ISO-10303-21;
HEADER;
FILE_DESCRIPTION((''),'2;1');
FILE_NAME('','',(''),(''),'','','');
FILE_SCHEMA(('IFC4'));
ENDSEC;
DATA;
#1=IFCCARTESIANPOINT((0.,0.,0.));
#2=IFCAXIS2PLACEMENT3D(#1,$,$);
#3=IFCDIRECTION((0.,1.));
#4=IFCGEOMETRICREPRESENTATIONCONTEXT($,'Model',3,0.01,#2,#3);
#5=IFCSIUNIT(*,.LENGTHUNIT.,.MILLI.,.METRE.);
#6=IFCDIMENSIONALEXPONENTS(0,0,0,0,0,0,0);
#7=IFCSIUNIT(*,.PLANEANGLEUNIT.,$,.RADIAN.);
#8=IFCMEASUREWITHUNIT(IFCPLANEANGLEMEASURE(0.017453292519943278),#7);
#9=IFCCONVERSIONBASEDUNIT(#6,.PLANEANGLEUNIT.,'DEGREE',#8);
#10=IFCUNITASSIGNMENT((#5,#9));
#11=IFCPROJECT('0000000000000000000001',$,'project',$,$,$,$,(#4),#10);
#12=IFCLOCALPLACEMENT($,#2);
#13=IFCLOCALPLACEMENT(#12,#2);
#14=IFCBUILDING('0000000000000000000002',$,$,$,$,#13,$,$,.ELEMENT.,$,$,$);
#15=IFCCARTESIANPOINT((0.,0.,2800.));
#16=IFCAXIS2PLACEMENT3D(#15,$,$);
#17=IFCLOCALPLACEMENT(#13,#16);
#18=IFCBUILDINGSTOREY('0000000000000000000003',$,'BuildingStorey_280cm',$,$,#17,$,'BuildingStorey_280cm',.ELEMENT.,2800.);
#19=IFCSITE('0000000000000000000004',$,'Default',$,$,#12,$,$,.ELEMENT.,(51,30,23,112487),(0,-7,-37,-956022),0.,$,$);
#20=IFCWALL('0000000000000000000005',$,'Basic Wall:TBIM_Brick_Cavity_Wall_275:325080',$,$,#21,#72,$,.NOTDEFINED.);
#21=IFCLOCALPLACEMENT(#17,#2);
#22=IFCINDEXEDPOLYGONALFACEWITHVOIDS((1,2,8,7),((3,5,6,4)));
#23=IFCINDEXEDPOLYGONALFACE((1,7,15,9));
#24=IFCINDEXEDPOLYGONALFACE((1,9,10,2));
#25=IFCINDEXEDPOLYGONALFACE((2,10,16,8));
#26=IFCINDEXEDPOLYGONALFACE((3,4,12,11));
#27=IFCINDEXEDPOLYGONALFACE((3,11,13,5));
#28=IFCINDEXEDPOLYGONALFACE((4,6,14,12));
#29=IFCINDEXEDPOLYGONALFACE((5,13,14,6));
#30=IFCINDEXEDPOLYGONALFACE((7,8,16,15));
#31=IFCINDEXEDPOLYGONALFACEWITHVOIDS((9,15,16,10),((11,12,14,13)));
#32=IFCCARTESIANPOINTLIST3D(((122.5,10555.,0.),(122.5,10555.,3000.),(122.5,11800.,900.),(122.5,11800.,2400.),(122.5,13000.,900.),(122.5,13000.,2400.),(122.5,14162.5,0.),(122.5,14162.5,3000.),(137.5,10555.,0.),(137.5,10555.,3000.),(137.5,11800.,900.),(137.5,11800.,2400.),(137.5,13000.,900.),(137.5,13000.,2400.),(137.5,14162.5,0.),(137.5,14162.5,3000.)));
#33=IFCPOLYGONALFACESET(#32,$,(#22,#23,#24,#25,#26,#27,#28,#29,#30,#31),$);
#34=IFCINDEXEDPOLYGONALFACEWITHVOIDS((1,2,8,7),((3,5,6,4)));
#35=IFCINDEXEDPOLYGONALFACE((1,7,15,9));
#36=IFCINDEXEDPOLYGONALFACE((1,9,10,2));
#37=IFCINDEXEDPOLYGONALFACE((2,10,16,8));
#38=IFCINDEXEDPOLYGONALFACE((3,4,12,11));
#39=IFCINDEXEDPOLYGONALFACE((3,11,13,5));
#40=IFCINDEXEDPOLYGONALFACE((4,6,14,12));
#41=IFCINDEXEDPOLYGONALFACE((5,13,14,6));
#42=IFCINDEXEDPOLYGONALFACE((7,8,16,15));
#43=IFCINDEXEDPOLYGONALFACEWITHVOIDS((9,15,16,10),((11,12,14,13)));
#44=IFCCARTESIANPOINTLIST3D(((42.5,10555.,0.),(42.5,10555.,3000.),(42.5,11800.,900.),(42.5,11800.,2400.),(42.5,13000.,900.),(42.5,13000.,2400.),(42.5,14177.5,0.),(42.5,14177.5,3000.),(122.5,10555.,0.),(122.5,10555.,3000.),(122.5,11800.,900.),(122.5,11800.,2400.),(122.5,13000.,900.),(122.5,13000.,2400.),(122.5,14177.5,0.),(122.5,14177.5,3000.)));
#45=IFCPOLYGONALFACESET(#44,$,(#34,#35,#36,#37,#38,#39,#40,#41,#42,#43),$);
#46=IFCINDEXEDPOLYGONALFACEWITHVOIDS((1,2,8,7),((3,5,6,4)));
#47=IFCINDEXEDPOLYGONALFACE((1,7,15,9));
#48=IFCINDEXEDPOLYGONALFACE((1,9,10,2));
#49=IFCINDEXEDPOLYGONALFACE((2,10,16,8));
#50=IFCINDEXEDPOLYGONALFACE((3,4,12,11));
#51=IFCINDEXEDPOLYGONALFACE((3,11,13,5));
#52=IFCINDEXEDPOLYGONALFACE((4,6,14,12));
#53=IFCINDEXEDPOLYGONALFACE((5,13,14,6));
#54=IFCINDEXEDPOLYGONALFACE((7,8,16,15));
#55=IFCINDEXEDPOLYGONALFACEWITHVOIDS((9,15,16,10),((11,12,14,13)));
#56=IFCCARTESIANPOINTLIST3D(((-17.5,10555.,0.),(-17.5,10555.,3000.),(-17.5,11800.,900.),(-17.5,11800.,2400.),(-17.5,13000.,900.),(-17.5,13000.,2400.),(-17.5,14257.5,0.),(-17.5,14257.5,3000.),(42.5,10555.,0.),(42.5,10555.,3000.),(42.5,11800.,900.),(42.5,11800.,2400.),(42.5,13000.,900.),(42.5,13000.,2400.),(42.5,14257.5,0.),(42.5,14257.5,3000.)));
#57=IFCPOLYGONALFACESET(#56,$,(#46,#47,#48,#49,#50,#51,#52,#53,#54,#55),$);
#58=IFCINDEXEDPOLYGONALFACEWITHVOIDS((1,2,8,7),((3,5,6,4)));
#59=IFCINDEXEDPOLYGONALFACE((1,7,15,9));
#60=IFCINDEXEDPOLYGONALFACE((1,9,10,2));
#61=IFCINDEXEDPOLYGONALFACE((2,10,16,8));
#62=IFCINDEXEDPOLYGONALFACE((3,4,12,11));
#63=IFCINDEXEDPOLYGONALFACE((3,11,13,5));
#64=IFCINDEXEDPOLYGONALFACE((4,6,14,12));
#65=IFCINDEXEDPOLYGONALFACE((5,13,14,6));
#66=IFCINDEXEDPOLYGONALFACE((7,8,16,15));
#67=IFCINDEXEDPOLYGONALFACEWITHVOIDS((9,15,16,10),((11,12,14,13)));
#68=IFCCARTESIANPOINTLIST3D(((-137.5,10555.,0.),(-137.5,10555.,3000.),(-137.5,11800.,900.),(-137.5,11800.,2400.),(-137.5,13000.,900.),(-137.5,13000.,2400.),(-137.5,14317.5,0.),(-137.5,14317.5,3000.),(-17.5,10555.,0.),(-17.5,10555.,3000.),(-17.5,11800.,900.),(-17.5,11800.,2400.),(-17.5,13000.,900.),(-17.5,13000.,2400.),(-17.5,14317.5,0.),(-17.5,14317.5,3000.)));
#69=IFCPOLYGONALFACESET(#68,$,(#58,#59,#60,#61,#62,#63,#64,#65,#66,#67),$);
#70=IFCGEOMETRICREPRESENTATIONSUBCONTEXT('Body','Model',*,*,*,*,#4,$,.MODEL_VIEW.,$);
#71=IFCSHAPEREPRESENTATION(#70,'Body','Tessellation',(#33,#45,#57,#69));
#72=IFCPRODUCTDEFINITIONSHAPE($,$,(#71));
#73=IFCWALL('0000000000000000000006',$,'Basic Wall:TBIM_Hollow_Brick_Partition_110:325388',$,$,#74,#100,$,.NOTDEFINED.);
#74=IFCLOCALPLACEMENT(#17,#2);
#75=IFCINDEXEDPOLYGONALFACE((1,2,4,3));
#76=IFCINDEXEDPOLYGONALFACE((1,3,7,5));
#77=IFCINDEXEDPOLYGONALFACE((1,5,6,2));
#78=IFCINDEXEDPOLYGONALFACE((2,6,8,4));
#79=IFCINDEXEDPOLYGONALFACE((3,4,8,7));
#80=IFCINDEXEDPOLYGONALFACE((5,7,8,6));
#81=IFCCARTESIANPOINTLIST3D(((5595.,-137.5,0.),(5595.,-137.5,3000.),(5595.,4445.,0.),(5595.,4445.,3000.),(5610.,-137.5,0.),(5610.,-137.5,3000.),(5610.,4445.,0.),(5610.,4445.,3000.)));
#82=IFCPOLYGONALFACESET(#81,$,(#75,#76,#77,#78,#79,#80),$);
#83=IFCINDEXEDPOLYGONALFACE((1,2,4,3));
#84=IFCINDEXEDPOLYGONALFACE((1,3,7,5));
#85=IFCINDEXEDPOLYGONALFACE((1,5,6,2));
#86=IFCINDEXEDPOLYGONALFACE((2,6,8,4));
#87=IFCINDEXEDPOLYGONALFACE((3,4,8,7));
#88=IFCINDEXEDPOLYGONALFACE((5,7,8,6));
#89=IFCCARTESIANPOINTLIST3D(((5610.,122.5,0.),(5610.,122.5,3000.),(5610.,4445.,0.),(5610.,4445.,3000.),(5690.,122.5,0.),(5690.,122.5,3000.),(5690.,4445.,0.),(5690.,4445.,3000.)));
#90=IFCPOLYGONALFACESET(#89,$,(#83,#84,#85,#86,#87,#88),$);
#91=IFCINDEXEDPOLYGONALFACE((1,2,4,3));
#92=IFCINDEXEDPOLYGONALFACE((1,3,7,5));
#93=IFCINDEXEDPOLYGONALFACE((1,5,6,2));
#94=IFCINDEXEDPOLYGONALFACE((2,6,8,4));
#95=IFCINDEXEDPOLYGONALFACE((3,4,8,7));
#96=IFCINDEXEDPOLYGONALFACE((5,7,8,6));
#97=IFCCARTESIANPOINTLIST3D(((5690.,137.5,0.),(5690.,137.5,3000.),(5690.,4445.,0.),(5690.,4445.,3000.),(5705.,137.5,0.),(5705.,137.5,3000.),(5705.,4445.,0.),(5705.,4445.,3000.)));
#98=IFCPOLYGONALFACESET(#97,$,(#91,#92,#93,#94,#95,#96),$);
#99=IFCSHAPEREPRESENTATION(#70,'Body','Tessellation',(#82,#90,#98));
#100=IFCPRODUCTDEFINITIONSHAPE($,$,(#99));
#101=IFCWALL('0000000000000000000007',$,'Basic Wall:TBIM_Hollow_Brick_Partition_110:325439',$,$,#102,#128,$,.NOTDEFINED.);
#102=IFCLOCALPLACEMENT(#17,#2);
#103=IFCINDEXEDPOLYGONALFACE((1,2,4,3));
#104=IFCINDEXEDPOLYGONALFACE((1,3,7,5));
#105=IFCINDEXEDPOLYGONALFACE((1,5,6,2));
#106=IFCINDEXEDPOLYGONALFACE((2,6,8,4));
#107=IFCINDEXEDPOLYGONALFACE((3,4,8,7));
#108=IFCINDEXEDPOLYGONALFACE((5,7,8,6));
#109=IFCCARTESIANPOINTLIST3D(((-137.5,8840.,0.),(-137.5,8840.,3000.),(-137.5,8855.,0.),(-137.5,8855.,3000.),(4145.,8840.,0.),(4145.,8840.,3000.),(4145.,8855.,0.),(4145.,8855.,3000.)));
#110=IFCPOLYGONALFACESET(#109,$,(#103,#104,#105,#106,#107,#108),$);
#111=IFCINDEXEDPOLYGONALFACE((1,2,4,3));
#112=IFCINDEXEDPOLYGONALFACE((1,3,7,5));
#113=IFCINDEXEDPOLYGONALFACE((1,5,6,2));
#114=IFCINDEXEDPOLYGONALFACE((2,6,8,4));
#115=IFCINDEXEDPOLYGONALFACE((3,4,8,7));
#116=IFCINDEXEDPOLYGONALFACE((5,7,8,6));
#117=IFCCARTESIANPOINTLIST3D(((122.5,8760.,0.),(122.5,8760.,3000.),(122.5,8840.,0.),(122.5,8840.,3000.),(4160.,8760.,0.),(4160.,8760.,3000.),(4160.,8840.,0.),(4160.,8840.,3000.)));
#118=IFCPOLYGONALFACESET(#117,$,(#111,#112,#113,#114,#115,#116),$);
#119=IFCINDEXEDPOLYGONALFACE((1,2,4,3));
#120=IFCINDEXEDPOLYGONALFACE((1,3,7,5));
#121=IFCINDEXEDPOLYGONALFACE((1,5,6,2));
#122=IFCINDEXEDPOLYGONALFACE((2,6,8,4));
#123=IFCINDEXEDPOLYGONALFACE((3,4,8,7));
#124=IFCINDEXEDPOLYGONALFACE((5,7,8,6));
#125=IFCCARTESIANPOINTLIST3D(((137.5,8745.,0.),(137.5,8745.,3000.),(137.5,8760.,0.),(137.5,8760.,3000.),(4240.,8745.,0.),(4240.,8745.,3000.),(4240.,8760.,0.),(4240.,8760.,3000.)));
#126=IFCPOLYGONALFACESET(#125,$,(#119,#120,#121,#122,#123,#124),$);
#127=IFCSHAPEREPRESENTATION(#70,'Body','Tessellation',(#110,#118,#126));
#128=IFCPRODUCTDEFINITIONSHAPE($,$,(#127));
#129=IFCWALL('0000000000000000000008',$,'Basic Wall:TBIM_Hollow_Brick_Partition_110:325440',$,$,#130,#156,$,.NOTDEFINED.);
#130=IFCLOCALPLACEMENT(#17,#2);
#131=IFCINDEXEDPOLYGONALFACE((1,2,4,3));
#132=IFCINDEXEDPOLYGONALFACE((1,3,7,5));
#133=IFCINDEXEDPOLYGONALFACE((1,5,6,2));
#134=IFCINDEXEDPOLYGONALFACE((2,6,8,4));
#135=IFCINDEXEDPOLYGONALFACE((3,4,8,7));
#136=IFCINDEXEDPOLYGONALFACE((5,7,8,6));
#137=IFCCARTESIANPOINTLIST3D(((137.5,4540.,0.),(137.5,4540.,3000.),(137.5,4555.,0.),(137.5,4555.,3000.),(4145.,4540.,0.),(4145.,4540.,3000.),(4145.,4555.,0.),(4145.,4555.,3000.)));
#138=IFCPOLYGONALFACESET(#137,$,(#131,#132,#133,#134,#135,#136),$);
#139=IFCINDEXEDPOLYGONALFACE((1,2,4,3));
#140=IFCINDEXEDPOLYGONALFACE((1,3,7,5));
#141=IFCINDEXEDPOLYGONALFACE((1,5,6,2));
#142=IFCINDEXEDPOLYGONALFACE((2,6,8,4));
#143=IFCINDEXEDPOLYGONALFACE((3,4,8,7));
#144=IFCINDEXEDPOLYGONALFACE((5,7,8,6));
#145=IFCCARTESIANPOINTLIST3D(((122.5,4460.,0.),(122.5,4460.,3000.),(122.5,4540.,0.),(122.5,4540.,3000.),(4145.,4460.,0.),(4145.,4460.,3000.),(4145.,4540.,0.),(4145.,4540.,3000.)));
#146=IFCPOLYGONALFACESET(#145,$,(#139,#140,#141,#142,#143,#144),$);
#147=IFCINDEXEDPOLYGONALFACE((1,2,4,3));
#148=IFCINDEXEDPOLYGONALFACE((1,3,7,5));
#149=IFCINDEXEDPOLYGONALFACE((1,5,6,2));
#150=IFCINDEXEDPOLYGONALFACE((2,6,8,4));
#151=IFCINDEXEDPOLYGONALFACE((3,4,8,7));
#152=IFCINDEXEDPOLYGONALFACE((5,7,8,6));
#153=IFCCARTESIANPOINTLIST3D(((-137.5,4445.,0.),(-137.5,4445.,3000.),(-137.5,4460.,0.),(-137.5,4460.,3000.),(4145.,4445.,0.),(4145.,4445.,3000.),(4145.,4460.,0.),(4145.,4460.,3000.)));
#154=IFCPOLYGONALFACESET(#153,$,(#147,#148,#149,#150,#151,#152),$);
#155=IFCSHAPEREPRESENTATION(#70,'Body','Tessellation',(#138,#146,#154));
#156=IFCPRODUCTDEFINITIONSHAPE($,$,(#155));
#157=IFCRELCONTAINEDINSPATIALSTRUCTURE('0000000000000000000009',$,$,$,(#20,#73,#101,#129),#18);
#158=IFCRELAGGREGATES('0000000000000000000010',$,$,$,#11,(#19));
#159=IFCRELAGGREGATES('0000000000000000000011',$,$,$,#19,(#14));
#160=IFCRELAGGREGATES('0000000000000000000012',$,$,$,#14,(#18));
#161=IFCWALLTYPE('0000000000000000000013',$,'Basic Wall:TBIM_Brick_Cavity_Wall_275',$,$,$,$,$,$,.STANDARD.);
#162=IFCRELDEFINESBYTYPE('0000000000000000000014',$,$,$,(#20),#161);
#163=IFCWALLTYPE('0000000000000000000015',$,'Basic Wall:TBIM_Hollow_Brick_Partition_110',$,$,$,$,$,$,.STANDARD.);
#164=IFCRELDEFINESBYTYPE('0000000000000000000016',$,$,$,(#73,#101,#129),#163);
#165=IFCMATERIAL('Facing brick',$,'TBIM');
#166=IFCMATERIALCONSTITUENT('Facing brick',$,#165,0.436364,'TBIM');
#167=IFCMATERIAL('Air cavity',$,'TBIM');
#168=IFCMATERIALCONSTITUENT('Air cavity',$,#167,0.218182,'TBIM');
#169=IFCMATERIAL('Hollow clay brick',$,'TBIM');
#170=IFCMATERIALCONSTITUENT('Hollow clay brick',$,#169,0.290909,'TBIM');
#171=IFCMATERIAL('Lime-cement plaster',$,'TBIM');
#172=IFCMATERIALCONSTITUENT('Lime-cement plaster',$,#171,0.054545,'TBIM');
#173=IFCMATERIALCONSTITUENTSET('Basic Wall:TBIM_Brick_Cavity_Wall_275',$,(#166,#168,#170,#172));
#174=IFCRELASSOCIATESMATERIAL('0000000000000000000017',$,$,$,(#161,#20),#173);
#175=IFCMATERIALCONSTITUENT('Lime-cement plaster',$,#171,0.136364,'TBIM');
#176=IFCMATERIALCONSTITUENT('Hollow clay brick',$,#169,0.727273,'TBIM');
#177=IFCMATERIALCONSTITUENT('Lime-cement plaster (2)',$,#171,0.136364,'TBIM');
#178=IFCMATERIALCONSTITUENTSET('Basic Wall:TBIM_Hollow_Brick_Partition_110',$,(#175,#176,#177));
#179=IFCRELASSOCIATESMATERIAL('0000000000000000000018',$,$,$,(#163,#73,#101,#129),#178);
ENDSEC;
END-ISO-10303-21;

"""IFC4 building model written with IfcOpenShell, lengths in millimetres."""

from ifc_helpers import new_model, entity, si_unit, converted_unit, direction, frame, origin, place, context, subcontext, project, spatial, indexed_curve, outline, extrude, material, constituent, constituent_set, type_object, element, save


model = new_model("IFC4")

# Units and contexts
model_context = context("Model", 3, precision=0.01, world=origin(), true_north=direction((0.0, 1.0)))
body_context = subcontext(model_context, "Body", "Model", "MODEL_VIEW")
ifc_project = project(units=[si_unit("LENGTHUNIT", "METRE", prefix="MILLI"), converted_unit("PLANEANGLEUNIT", "DEGREE", entity("IfcPlaneAngleMeasure", 0.017453292519943278), si_unit("PLANEANGLEUNIT", "RADIAN"), dimensions=[0, 0, 0, 0, 0, 0, 0])], contexts=[model_context])

# Site, building, storey
site_placement = place(None, origin())
site = spatial("IfcSite", under=ifc_project, at=site_placement, Name="Default", CompositionType="ELEMENT", RefLatitude=(51, 30, 23, 112487), RefLongitude=(0, -7, -37, -956022), RefElevation=0.0)
building_placement = place(site_placement, origin())
building = spatial("IfcBuilding", under=site, at=building_placement, CompositionType="ELEMENT")
storey_placement = place(building_placement, frame((0.0, 0.0, 2800.0)))
storey = spatial("IfcBuildingStorey", under=building, at=storey_placement, Name="BuildingStorey_280cm", LongName="BuildingStorey_280cm", CompositionType="ELEMENT", Elevation=2800.0)

# Shared definitions
ifc_material_1 = material(Name="Lime-cement plaster", Category="TBIM")

# Shared definitions
ifc_material_2 = material(Name="Facing brick", Category="TBIM")
ifc_constituent_1 = constituent(ifc_material_2, Name="Facing brick", Category="TBIM", fraction=0.436364)
ifc_material_3 = material(Name="Air cavity", Category="TBIM")
ifc_constituent_2 = constituent(ifc_material_3, Name="Air cavity", Category="TBIM", fraction=0.218182)
ifc_material_4 = material(Name="Hollow clay brick", Category="TBIM")
ifc_constituent_3 = constituent(ifc_material_4, Name="Hollow clay brick", Category="TBIM", fraction=0.290909)
ifc_constituent_4 = constituent(ifc_material_1, Name="Lime-cement plaster", Category="TBIM", fraction=0.054545)
ifc_constituent_set_1 = constituent_set(constituents=[ifc_constituent_1, ifc_constituent_2, ifc_constituent_3, ifc_constituent_4], Name="Basic Wall:TBIM_Brick_Cavity_Wall_275")
wall_type_1 = type_object("IfcWallType", Name="Basic Wall:TBIM_Brick_Cavity_Wall_275", PredefinedType="STANDARD", material=ifc_constituent_set_1)

# Wall, opening
wall_1_placement = place(storey_placement, frame((0.0, 10555.0, 0.0), z_axis=(0.0, 0.0, 1.0), x_axis=(0.0, 1.0, 0.0)))
wall_1 = element("IfcWall", 1, at=wall_1_placement, inside=storey, type_object=wall_type_1, material=ifc_constituent_set_1, Name="Basic Wall:TBIM_Brick_Cavity_Wall_275:325080", PredefinedType="NOTDEFINED", context=body_context, shape_type="SweptSolid", body=[
    extrude(outline(indexed_curve([(-1500.0, -1803.7), (1500.0, -1803.8), (1500.0, 1803.7), (-1500.0, 1803.7), (-1500.0, -1803.7)], self_intersect=False), holes=[indexed_curve([(900.0, 558.8), (900.0, -641.2), (-600.0, -641.2), (-600.0, 558.8), (900.0, 558.8)], self_intersect=False)]), frame((1803.7, -122.5, 1500.0), z_axis=(0.0, -1.0, 0.0), x_axis=(0.0, 0.0, 1.0)), (0.0, 0.0, 1.0), 15.0),
    extrude(outline(indexed_curve([(-1500.0, -1811.2), (1500.0, -1811.2), (1500.0, 1811.2), (-1500.0, 1811.2), (-1500.0, -1811.2)], self_intersect=False), holes=[indexed_curve([(900.0, 566.3), (900.0, -633.7), (-600.0, -633.7), (-600.0, 566.3), (900.0, 566.3)], self_intersect=False)]), frame((1811.2, -42.5, 1500.0), z_axis=(0.0, -1.0, 0.0), x_axis=(0.0, 0.0, 1.0)), (0.0, 0.0, 1.0), 80.0),
    extrude(outline(indexed_curve([(-1500.0, -1851.2), (1500.0, -1851.2), (1500.0, 1851.2), (-1500.0, 1851.2), (-1500.0, -1851.2)], self_intersect=False), holes=[indexed_curve([(900.0, 606.3), (900.0, -593.7), (-600.0, -593.7), (-600.0, 606.3), (900.0, 606.3)], self_intersect=False)]), frame((1851.2, 17.5, 1500.0), z_axis=(0.0, -1.0, 0.0), x_axis=(0.0, 0.0, 1.0)), (0.0, 0.0, 1.0), 60.0),
    extrude(outline(indexed_curve([(-1881.2, -1500.0), (1881.2, -1500.0), (1881.2, 1500.0), (-1881.2, 1500.0), (-1881.2, -1500.0)], self_intersect=False), holes=[indexed_curve([(-636.3, 900.0), (563.7, 900.0), (563.7, -600.0), (-636.3, -600.0), (-636.3, 900.0)], self_intersect=False)]), frame((1881.2, 137.5, 1500.0), z_axis=(0.0, -1.0, 0.0), x_axis=(1.0, 0.0, 0.0)), (0.0, 0.0, 1.0), 120.0),
])
opening_1_placement = place(wall_1_placement, frame((1245.0, -137.5, 900.0)))
element("IfcOpeningElement", 2, at=opening_1_placement, cuts=wall_1, PredefinedType="OPENING", context=body_context, shape_type="SweptSolid", body=[
    extrude(outline(indexed_curve([(1500.0, 0.0), (1500.0, 1200.0), (0.0, 1200.0), (0.0, 0.0), (1500.0, 0.0)], self_intersect=False)), frame((0.0, 0.0, 0.0), z_axis=(0.0, 1.0, 0.0), x_axis=(0.0, 0.0, 1.0)), (0.0, 0.0, 1.0), 275.0),
])

# Wall
ifc_constituent_5 = constituent(ifc_material_1, Name="Lime-cement plaster", Category="TBIM", fraction=0.136364)
ifc_constituent_6 = constituent(ifc_material_4, Name="Hollow clay brick", Category="TBIM", fraction=0.727273)
ifc_constituent_7 = constituent(ifc_material_1, Name="Lime-cement plaster (2)", Category="TBIM", fraction=0.136364)
ifc_constituent_set_2 = constituent_set(constituents=[ifc_constituent_5, ifc_constituent_6, ifc_constituent_7], Name="Basic Wall:TBIM_Hollow_Brick_Partition_110")
wall_type_2 = type_object("IfcWallType", Name="Basic Wall:TBIM_Hollow_Brick_Partition_110", PredefinedType="STANDARD", material=ifc_constituent_set_2)
wall_2_placement = place(storey_placement, frame((5650.0, 137.5, 0.0), z_axis=(0.0, 0.0, 1.0), x_axis=(0.0, 1.0, 0.0)))
element("IfcWall", 3, at=wall_2_placement, inside=storey, type_object=wall_type_2, material=ifc_constituent_set_2, Name="Basic Wall:TBIM_Hollow_Brick_Partition_110:325388", PredefinedType="NOTDEFINED", context=body_context, shape_type="SweptSolid", body=[
    extrude(outline(indexed_curve([(-7.5, -2291.2), (7.5, -2291.2), (7.5, 2291.2), (-7.5, 2291.2), (-7.5, -2291.2)], self_intersect=False)), frame((2016.2, 47.5, 0.0), z_axis=(0.0, 0.0, 1.0), x_axis=(0.0, -1.0, 0.0)), (0.0, 0.0, 1.0), 3000.0),
    extrude(outline(indexed_curve([(-2161.2, -40.0), (2161.2, -40.0), (2161.2, 40.0), (-2161.3, 40.0), (-2161.2, -40.0)], self_intersect=False)), frame((2146.2, 0.0, 0.0)), (0.0, 0.0, 1.0), 3000.0),
    extrude(outline(indexed_curve([(-7.5, -2153.8), (7.5, -2153.8), (7.5, 2153.8), (-7.5, 2153.8), (-7.5, -2153.8)], self_intersect=False)), frame((2153.8, -47.5, 0.0), z_axis=(0.0, 0.0, 1.0), x_axis=(0.0, 1.0, 0.0)), (0.0, 0.0, 1.0), 3000.0),
])

# Walls
wall_3_placement = place(storey_placement, frame((137.5, 8800.0, 0.0)))
element("IfcWall", 4, at=wall_3_placement, inside=storey, type_object=wall_type_2, material=ifc_constituent_set_2, Name="Basic Wall:TBIM_Hollow_Brick_Partition_110:325439", PredefinedType="NOTDEFINED", context=body_context, shape_type="SweptSolid", body=[
    extrude(outline(indexed_curve([(-7.5, -2141.2), (7.5, -2141.2), (7.5, 2141.2), (-7.5, 2141.2), (-7.5, -2141.2)], self_intersect=False)), frame((1866.2, 47.5, 0.0), z_axis=(0.0, 0.0, 1.0), x_axis=(0.0, -1.0, 0.0)), (0.0, 0.0, 1.0), 3000.0),
    extrude(outline(indexed_curve([(-2018.7, -40.0), (2018.7, -40.0), (2018.7, 40.0), (-2018.7, 40.0), (-2018.7, -40.0)], self_intersect=False)), frame((2003.7, 0.0, 0.0)), (0.0, 0.0, 1.0), 3000.0),
    extrude(outline(indexed_curve([(-7.5, -2051.2), (7.5, -2051.2), (7.5, 2051.2), (-7.5, 2051.2), (-7.5, -2051.2)], self_intersect=False)), frame((2051.2, -47.5, 0.0), z_axis=(0.0, 0.0, 1.0), x_axis=(0.0, 1.0, 0.0)), (0.0, 0.0, 1.0), 3000.0),
])
wall_4_placement = place(storey_placement, frame((137.5, 4500.0, 0.0)))
element("IfcWall", 5, at=wall_4_placement, inside=storey, type_object=wall_type_2, material=ifc_constituent_set_2, Name="Basic Wall:TBIM_Hollow_Brick_Partition_110:325440", PredefinedType="NOTDEFINED", context=body_context, shape_type="SweptSolid", body=[
    extrude(outline(indexed_curve([(-7.5, -2003.7), (7.5, -2003.7), (7.5, 2003.7), (-7.5, 2003.7), (-7.5, -2003.7)], self_intersect=False)), frame((2003.7, 47.5, 0.0), z_axis=(0.0, 0.0, 1.0), x_axis=(0.0, -1.0, 0.0)), (0.0, 0.0, 1.0), 3000.0),
    extrude(outline(indexed_curve([(-2011.2, -40.0), (2011.2, -40.0), (2011.2, 40.0), (-2011.2, 40.0), (-2011.2, -40.0)], self_intersect=False)), frame((1996.2, 0.0, 0.0)), (0.0, 0.0, 1.0), 3000.0),
    extrude(outline(indexed_curve([(-7.5, -2141.2), (7.5, -2141.2), (7.5, 2141.2), (-7.5, 2141.2), (-7.5, -2141.2)], self_intersect=False)), frame((1866.2, -47.5, 0.0), z_axis=(0.0, 0.0, 1.0), x_axis=(0.0, 1.0, 0.0)), (0.0, 0.0, 1.0), 3000.0),
])

save(model, "model.ifc")
